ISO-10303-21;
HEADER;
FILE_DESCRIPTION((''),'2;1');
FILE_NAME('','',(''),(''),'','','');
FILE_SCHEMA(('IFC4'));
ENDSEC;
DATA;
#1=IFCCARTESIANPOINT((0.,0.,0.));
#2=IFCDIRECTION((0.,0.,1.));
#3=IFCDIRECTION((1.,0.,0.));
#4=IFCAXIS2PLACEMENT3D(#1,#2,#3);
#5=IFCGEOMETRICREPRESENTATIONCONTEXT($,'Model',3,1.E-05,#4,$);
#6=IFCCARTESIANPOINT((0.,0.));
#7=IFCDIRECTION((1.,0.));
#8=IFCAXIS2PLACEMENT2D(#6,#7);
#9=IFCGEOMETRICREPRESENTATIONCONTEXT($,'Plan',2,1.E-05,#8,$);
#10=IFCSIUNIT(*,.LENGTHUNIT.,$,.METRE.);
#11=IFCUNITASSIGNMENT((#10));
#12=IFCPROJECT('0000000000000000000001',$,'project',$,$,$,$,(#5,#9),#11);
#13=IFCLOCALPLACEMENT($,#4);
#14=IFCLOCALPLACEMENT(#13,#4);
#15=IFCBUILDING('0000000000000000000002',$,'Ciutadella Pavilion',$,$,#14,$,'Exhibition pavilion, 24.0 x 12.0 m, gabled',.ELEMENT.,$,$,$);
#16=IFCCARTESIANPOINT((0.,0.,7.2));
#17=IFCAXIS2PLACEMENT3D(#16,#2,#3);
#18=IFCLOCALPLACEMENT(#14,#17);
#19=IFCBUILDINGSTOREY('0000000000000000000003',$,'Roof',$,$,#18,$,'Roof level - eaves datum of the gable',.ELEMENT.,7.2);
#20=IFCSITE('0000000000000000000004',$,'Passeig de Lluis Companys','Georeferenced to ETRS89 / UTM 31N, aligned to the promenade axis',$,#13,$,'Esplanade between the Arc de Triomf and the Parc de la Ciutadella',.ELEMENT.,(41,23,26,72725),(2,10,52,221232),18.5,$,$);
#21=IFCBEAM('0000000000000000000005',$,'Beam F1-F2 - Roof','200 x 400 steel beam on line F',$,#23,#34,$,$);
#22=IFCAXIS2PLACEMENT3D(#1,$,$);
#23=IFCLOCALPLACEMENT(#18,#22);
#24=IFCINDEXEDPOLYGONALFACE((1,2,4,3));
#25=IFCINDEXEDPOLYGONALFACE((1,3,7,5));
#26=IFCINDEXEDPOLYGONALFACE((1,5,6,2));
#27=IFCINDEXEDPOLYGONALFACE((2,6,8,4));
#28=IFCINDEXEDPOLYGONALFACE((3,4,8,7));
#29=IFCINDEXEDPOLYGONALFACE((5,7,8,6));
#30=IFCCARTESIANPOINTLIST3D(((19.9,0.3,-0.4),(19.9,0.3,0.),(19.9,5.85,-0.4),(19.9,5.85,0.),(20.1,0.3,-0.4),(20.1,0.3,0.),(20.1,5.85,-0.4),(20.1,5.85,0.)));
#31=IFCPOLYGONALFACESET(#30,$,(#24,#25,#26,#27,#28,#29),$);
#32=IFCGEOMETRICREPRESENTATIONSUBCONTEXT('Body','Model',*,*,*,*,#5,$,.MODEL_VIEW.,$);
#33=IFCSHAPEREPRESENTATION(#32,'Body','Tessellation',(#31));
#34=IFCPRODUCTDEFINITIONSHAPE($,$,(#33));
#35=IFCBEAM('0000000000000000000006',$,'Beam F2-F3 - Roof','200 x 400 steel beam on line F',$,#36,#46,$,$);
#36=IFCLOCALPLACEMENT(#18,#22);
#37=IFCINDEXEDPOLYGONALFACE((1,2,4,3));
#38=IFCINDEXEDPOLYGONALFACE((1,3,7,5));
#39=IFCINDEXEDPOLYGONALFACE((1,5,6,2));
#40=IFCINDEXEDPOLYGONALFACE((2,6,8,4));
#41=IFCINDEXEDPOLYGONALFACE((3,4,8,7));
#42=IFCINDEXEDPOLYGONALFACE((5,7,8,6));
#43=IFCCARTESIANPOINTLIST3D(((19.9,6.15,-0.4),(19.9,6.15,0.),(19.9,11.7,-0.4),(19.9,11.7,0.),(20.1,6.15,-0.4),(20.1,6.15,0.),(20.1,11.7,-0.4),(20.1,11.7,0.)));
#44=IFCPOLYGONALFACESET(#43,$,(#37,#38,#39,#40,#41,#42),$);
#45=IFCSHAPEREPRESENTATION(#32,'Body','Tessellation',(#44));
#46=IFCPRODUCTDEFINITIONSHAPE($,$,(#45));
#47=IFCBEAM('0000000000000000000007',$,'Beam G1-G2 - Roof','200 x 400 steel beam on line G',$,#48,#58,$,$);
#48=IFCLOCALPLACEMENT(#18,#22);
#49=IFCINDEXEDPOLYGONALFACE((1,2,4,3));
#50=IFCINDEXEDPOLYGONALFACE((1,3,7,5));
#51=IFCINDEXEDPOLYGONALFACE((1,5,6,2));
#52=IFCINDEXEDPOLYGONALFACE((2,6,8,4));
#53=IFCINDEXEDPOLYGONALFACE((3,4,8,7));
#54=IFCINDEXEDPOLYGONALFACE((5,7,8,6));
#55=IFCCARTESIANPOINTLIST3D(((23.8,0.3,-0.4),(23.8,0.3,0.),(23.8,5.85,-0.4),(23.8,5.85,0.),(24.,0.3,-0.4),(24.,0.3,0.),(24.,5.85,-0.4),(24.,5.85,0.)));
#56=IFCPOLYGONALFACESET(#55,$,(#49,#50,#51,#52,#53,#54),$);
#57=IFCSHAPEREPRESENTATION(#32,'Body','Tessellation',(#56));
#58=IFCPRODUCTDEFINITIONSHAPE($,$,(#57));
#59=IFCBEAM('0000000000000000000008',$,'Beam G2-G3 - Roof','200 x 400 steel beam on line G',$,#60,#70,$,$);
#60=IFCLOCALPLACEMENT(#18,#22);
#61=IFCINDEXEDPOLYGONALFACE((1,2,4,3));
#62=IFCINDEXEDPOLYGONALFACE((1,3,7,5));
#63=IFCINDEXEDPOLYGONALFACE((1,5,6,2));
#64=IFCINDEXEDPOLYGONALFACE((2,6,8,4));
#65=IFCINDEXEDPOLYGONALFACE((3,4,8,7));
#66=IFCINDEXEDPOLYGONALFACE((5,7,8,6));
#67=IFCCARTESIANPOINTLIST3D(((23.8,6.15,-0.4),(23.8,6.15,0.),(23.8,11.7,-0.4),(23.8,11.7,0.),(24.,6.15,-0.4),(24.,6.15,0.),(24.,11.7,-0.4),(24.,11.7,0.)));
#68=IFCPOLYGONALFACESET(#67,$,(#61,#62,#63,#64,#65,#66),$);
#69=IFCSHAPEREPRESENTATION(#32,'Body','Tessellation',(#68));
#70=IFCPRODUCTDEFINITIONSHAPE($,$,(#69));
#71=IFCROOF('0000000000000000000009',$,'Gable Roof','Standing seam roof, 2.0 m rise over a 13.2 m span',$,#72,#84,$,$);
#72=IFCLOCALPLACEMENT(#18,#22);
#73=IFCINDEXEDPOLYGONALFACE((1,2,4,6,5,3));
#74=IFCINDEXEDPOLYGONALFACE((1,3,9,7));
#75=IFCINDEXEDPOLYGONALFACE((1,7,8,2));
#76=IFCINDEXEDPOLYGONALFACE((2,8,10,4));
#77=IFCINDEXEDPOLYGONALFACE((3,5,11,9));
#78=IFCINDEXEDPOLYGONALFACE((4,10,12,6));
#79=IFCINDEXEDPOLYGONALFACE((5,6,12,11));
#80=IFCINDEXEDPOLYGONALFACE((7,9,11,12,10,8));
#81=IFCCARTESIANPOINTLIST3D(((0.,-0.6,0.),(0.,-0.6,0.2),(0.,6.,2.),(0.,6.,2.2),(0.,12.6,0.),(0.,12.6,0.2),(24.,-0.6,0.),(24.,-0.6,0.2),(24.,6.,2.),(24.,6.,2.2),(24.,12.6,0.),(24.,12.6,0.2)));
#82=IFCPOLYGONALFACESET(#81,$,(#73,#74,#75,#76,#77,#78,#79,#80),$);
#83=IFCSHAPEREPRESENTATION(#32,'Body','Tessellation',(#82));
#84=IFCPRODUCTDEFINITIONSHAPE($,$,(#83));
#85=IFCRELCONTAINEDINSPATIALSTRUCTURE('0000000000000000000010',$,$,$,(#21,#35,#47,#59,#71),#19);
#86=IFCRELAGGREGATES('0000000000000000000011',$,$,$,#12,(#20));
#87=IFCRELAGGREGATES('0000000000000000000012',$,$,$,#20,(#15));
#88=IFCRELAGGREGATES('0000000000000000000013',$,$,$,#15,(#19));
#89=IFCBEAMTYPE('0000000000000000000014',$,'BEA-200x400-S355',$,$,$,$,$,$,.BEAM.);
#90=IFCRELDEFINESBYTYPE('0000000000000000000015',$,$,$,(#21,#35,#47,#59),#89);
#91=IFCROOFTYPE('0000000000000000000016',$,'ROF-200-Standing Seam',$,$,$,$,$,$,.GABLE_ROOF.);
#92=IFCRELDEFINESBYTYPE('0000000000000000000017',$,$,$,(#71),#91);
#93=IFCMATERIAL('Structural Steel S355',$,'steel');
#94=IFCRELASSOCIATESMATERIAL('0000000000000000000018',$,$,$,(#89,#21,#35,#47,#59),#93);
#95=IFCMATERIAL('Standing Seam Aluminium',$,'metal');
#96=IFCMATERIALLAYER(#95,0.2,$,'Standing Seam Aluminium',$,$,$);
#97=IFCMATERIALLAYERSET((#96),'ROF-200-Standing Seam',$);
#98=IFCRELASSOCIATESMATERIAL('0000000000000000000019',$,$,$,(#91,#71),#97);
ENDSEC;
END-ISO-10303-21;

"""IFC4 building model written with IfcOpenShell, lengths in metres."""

from ifc_helpers import new_model, si_unit, frame, origin_with_axes, origin_2d_with_axis, place, context, subcontext, project, spatial, line, indexed_curve, rectangle, outline, extrude, material, layer, layer_set, layer_usage, material_profile, profile_set, profile_usage, type_object, element, save


model = new_model("IFC4")

# Units and contexts
model_context = context("Model", 3, precision=1e-05, world=origin_with_axes())
plan_context = context("Plan", 2, precision=1e-05, world=origin_2d_with_axis())
body_context = subcontext(model_context, "Body", "Model", "MODEL_VIEW")
ifc_project = project(units=[si_unit("LENGTHUNIT", "METRE")], contexts=[model_context, plan_context])

# Site, building, storey
site_placement = place(None, origin_with_axes())
site = spatial("IfcSite", under=ifc_project, at=site_placement, Name="Passeig de Lluis Companys", Description="Georeferenced to ETRS89 / UTM 31N, aligned to the promenade axis", LongName="Esplanade between the Arc de Triomf and the Parc de la Ciutadella", CompositionType="ELEMENT", RefLatitude=(41, 23, 26, 72725), RefLongitude=(2, 10, 52, 221232), RefElevation=18.5)
building_placement = place(site_placement, origin_with_axes())
building = spatial("IfcBuilding", under=site, at=building_placement, Name="Ciutadella Pavilion", LongName="Exhibition pavilion, 24.0 x 12.0 m, gabled", CompositionType="ELEMENT")
storey_placement = place(building_placement, frame((0.0, 0.0, 7.2), z_axis=(0.0, 0.0, 1.0), x_axis=(1.0, 0.0, 0.0)))
storey = spatial("IfcBuildingStorey", under=building, at=storey_placement, Name="Roof", LongName="Roof level - eaves datum of the gable", CompositionType="ELEMENT", Elevation=7.2)

# Beams
ifc_material_1 = material(Name="Structural Steel S355", Category="steel")
ifc_material_profile = material_profile(ifc_material_1, rectangle(XDim=0.2, YDim=0.4))
ifc_profile_set = profile_set([ifc_material_profile], Name="BEA-200x400-S355")
beam_type = type_object("IfcBeamType", Name="BEA-200x400-S355", PredefinedType="BEAM", material=ifc_profile_set)
ifc_profile_usage_1 = profile_usage(ifc_profile_set)
beam_1_placement = place(storey_placement, frame((19.9, 0.3, -0.4), z_axis=(0.0, 1.0, 0.0), x_axis=(0.0, 0.0, 1.0)))
element("IfcBeam", 1, at=beam_1_placement, inside=storey, type_object=beam_type, material=ifc_profile_usage_1, Name="Beam F1-F2 - Roof", Description="200 x 400 steel beam on line F", context=body_context, shape_type="SweptSolid", body=[
    extrude(outline(indexed_curve([(0.0, 0.0), (0.4, 0.0), (0.4, 0.2), (0.0, 0.2)], segments=[line(1, 2, 3, 4, 1)])), origin_with_axes(), (0.0, 0.0, 1.0), 5.55),
])
ifc_profile_usage_2 = profile_usage(ifc_profile_set)
beam_2_placement = place(storey_placement, frame((19.9, 6.15, -0.4), z_axis=(0.0, 1.0, 0.0), x_axis=(0.0, 0.0, 1.0)))
element("IfcBeam", 2, at=beam_2_placement, inside=storey, type_object=beam_type, material=ifc_profile_usage_2, Name="Beam F2-F3 - Roof", Description="200 x 400 steel beam on line F", context=body_context, shape_type="SweptSolid", body=[
    extrude(outline(indexed_curve([(0.0, 0.0), (0.4, 0.0), (0.4, 0.2), (0.0, 0.2)], segments=[line(1, 2, 3, 4, 1)])), origin_with_axes(), (0.0, 0.0, 1.0), 5.55),
])
ifc_profile_usage_3 = profile_usage(ifc_profile_set)
beam_3_placement = place(storey_placement, frame((23.8, 0.3, -0.4), z_axis=(0.0, 1.0, 0.0), x_axis=(0.0, 0.0, 1.0)))
element("IfcBeam", 3, at=beam_3_placement, inside=storey, type_object=beam_type, material=ifc_profile_usage_3, Name="Beam G1-G2 - Roof", Description="200 x 400 steel beam on line G", context=body_context, shape_type="SweptSolid", body=[
    extrude(outline(indexed_curve([(0.0, 0.0), (0.4, 0.0), (0.4, 0.2), (0.0, 0.2)], segments=[line(1, 2, 3, 4, 1)])), origin_with_axes(), (0.0, 0.0, 1.0), 5.55),
])
ifc_profile_usage_4 = profile_usage(ifc_profile_set)
beam_4_placement = place(storey_placement, frame((23.8, 6.15, -0.4), z_axis=(0.0, 1.0, 0.0), x_axis=(0.0, 0.0, 1.0)))
element("IfcBeam", 4, at=beam_4_placement, inside=storey, type_object=beam_type, material=ifc_profile_usage_4, Name="Beam G2-G3 - Roof", Description="200 x 400 steel beam on line G", context=body_context, shape_type="SweptSolid", body=[
    extrude(outline(indexed_curve([(0.0, 0.0), (0.4, 0.0), (0.4, 0.2), (0.0, 0.2)], segments=[line(1, 2, 3, 4, 1)])), origin_with_axes(), (0.0, 0.0, 1.0), 5.55),
])

# Roof
ifc_material_2 = material(Name="Standing Seam Aluminium", Category="metal")
ifc_layer = layer(ifc_material_2, 0.2, Name="Standing Seam Aluminium")
ifc_layer_set = layer_set([ifc_layer], Name="ROF-200-Standing Seam")
ifc_layer_usage = layer_usage(ifc_layer_set, "AXIS3", "POSITIVE", 0.0)
roof_type = type_object("IfcRoofType", Name="ROF-200-Standing Seam", PredefinedType="GABLE_ROOF", material=ifc_layer_set)
roof_placement = place(storey_placement, frame((0.0, -0.6, 0.0), z_axis=(1.0, 0.0, 0.0), x_axis=(0.0, 1.0, 0.0)))
element("IfcRoof", 5, at=roof_placement, inside=storey, type_object=roof_type, material=ifc_layer_usage, Name="Gable Roof", Description="Standing seam roof, 2.0 m rise over a 13.2 m span", context=body_context, shape_type="SweptSolid", body=[
    extrude(outline(indexed_curve([(0.0, 0.0), (6.6, 2.0), (13.2, 0.0), (13.2, 0.2), (6.6, 2.2), (0.0, 0.2)], segments=[line(1, 2, 3, 4, 5, 6, 1)])), origin_with_axes(), (0.0, 0.0, 1.0), 24.0),
])

save(model, "model.ifc")
